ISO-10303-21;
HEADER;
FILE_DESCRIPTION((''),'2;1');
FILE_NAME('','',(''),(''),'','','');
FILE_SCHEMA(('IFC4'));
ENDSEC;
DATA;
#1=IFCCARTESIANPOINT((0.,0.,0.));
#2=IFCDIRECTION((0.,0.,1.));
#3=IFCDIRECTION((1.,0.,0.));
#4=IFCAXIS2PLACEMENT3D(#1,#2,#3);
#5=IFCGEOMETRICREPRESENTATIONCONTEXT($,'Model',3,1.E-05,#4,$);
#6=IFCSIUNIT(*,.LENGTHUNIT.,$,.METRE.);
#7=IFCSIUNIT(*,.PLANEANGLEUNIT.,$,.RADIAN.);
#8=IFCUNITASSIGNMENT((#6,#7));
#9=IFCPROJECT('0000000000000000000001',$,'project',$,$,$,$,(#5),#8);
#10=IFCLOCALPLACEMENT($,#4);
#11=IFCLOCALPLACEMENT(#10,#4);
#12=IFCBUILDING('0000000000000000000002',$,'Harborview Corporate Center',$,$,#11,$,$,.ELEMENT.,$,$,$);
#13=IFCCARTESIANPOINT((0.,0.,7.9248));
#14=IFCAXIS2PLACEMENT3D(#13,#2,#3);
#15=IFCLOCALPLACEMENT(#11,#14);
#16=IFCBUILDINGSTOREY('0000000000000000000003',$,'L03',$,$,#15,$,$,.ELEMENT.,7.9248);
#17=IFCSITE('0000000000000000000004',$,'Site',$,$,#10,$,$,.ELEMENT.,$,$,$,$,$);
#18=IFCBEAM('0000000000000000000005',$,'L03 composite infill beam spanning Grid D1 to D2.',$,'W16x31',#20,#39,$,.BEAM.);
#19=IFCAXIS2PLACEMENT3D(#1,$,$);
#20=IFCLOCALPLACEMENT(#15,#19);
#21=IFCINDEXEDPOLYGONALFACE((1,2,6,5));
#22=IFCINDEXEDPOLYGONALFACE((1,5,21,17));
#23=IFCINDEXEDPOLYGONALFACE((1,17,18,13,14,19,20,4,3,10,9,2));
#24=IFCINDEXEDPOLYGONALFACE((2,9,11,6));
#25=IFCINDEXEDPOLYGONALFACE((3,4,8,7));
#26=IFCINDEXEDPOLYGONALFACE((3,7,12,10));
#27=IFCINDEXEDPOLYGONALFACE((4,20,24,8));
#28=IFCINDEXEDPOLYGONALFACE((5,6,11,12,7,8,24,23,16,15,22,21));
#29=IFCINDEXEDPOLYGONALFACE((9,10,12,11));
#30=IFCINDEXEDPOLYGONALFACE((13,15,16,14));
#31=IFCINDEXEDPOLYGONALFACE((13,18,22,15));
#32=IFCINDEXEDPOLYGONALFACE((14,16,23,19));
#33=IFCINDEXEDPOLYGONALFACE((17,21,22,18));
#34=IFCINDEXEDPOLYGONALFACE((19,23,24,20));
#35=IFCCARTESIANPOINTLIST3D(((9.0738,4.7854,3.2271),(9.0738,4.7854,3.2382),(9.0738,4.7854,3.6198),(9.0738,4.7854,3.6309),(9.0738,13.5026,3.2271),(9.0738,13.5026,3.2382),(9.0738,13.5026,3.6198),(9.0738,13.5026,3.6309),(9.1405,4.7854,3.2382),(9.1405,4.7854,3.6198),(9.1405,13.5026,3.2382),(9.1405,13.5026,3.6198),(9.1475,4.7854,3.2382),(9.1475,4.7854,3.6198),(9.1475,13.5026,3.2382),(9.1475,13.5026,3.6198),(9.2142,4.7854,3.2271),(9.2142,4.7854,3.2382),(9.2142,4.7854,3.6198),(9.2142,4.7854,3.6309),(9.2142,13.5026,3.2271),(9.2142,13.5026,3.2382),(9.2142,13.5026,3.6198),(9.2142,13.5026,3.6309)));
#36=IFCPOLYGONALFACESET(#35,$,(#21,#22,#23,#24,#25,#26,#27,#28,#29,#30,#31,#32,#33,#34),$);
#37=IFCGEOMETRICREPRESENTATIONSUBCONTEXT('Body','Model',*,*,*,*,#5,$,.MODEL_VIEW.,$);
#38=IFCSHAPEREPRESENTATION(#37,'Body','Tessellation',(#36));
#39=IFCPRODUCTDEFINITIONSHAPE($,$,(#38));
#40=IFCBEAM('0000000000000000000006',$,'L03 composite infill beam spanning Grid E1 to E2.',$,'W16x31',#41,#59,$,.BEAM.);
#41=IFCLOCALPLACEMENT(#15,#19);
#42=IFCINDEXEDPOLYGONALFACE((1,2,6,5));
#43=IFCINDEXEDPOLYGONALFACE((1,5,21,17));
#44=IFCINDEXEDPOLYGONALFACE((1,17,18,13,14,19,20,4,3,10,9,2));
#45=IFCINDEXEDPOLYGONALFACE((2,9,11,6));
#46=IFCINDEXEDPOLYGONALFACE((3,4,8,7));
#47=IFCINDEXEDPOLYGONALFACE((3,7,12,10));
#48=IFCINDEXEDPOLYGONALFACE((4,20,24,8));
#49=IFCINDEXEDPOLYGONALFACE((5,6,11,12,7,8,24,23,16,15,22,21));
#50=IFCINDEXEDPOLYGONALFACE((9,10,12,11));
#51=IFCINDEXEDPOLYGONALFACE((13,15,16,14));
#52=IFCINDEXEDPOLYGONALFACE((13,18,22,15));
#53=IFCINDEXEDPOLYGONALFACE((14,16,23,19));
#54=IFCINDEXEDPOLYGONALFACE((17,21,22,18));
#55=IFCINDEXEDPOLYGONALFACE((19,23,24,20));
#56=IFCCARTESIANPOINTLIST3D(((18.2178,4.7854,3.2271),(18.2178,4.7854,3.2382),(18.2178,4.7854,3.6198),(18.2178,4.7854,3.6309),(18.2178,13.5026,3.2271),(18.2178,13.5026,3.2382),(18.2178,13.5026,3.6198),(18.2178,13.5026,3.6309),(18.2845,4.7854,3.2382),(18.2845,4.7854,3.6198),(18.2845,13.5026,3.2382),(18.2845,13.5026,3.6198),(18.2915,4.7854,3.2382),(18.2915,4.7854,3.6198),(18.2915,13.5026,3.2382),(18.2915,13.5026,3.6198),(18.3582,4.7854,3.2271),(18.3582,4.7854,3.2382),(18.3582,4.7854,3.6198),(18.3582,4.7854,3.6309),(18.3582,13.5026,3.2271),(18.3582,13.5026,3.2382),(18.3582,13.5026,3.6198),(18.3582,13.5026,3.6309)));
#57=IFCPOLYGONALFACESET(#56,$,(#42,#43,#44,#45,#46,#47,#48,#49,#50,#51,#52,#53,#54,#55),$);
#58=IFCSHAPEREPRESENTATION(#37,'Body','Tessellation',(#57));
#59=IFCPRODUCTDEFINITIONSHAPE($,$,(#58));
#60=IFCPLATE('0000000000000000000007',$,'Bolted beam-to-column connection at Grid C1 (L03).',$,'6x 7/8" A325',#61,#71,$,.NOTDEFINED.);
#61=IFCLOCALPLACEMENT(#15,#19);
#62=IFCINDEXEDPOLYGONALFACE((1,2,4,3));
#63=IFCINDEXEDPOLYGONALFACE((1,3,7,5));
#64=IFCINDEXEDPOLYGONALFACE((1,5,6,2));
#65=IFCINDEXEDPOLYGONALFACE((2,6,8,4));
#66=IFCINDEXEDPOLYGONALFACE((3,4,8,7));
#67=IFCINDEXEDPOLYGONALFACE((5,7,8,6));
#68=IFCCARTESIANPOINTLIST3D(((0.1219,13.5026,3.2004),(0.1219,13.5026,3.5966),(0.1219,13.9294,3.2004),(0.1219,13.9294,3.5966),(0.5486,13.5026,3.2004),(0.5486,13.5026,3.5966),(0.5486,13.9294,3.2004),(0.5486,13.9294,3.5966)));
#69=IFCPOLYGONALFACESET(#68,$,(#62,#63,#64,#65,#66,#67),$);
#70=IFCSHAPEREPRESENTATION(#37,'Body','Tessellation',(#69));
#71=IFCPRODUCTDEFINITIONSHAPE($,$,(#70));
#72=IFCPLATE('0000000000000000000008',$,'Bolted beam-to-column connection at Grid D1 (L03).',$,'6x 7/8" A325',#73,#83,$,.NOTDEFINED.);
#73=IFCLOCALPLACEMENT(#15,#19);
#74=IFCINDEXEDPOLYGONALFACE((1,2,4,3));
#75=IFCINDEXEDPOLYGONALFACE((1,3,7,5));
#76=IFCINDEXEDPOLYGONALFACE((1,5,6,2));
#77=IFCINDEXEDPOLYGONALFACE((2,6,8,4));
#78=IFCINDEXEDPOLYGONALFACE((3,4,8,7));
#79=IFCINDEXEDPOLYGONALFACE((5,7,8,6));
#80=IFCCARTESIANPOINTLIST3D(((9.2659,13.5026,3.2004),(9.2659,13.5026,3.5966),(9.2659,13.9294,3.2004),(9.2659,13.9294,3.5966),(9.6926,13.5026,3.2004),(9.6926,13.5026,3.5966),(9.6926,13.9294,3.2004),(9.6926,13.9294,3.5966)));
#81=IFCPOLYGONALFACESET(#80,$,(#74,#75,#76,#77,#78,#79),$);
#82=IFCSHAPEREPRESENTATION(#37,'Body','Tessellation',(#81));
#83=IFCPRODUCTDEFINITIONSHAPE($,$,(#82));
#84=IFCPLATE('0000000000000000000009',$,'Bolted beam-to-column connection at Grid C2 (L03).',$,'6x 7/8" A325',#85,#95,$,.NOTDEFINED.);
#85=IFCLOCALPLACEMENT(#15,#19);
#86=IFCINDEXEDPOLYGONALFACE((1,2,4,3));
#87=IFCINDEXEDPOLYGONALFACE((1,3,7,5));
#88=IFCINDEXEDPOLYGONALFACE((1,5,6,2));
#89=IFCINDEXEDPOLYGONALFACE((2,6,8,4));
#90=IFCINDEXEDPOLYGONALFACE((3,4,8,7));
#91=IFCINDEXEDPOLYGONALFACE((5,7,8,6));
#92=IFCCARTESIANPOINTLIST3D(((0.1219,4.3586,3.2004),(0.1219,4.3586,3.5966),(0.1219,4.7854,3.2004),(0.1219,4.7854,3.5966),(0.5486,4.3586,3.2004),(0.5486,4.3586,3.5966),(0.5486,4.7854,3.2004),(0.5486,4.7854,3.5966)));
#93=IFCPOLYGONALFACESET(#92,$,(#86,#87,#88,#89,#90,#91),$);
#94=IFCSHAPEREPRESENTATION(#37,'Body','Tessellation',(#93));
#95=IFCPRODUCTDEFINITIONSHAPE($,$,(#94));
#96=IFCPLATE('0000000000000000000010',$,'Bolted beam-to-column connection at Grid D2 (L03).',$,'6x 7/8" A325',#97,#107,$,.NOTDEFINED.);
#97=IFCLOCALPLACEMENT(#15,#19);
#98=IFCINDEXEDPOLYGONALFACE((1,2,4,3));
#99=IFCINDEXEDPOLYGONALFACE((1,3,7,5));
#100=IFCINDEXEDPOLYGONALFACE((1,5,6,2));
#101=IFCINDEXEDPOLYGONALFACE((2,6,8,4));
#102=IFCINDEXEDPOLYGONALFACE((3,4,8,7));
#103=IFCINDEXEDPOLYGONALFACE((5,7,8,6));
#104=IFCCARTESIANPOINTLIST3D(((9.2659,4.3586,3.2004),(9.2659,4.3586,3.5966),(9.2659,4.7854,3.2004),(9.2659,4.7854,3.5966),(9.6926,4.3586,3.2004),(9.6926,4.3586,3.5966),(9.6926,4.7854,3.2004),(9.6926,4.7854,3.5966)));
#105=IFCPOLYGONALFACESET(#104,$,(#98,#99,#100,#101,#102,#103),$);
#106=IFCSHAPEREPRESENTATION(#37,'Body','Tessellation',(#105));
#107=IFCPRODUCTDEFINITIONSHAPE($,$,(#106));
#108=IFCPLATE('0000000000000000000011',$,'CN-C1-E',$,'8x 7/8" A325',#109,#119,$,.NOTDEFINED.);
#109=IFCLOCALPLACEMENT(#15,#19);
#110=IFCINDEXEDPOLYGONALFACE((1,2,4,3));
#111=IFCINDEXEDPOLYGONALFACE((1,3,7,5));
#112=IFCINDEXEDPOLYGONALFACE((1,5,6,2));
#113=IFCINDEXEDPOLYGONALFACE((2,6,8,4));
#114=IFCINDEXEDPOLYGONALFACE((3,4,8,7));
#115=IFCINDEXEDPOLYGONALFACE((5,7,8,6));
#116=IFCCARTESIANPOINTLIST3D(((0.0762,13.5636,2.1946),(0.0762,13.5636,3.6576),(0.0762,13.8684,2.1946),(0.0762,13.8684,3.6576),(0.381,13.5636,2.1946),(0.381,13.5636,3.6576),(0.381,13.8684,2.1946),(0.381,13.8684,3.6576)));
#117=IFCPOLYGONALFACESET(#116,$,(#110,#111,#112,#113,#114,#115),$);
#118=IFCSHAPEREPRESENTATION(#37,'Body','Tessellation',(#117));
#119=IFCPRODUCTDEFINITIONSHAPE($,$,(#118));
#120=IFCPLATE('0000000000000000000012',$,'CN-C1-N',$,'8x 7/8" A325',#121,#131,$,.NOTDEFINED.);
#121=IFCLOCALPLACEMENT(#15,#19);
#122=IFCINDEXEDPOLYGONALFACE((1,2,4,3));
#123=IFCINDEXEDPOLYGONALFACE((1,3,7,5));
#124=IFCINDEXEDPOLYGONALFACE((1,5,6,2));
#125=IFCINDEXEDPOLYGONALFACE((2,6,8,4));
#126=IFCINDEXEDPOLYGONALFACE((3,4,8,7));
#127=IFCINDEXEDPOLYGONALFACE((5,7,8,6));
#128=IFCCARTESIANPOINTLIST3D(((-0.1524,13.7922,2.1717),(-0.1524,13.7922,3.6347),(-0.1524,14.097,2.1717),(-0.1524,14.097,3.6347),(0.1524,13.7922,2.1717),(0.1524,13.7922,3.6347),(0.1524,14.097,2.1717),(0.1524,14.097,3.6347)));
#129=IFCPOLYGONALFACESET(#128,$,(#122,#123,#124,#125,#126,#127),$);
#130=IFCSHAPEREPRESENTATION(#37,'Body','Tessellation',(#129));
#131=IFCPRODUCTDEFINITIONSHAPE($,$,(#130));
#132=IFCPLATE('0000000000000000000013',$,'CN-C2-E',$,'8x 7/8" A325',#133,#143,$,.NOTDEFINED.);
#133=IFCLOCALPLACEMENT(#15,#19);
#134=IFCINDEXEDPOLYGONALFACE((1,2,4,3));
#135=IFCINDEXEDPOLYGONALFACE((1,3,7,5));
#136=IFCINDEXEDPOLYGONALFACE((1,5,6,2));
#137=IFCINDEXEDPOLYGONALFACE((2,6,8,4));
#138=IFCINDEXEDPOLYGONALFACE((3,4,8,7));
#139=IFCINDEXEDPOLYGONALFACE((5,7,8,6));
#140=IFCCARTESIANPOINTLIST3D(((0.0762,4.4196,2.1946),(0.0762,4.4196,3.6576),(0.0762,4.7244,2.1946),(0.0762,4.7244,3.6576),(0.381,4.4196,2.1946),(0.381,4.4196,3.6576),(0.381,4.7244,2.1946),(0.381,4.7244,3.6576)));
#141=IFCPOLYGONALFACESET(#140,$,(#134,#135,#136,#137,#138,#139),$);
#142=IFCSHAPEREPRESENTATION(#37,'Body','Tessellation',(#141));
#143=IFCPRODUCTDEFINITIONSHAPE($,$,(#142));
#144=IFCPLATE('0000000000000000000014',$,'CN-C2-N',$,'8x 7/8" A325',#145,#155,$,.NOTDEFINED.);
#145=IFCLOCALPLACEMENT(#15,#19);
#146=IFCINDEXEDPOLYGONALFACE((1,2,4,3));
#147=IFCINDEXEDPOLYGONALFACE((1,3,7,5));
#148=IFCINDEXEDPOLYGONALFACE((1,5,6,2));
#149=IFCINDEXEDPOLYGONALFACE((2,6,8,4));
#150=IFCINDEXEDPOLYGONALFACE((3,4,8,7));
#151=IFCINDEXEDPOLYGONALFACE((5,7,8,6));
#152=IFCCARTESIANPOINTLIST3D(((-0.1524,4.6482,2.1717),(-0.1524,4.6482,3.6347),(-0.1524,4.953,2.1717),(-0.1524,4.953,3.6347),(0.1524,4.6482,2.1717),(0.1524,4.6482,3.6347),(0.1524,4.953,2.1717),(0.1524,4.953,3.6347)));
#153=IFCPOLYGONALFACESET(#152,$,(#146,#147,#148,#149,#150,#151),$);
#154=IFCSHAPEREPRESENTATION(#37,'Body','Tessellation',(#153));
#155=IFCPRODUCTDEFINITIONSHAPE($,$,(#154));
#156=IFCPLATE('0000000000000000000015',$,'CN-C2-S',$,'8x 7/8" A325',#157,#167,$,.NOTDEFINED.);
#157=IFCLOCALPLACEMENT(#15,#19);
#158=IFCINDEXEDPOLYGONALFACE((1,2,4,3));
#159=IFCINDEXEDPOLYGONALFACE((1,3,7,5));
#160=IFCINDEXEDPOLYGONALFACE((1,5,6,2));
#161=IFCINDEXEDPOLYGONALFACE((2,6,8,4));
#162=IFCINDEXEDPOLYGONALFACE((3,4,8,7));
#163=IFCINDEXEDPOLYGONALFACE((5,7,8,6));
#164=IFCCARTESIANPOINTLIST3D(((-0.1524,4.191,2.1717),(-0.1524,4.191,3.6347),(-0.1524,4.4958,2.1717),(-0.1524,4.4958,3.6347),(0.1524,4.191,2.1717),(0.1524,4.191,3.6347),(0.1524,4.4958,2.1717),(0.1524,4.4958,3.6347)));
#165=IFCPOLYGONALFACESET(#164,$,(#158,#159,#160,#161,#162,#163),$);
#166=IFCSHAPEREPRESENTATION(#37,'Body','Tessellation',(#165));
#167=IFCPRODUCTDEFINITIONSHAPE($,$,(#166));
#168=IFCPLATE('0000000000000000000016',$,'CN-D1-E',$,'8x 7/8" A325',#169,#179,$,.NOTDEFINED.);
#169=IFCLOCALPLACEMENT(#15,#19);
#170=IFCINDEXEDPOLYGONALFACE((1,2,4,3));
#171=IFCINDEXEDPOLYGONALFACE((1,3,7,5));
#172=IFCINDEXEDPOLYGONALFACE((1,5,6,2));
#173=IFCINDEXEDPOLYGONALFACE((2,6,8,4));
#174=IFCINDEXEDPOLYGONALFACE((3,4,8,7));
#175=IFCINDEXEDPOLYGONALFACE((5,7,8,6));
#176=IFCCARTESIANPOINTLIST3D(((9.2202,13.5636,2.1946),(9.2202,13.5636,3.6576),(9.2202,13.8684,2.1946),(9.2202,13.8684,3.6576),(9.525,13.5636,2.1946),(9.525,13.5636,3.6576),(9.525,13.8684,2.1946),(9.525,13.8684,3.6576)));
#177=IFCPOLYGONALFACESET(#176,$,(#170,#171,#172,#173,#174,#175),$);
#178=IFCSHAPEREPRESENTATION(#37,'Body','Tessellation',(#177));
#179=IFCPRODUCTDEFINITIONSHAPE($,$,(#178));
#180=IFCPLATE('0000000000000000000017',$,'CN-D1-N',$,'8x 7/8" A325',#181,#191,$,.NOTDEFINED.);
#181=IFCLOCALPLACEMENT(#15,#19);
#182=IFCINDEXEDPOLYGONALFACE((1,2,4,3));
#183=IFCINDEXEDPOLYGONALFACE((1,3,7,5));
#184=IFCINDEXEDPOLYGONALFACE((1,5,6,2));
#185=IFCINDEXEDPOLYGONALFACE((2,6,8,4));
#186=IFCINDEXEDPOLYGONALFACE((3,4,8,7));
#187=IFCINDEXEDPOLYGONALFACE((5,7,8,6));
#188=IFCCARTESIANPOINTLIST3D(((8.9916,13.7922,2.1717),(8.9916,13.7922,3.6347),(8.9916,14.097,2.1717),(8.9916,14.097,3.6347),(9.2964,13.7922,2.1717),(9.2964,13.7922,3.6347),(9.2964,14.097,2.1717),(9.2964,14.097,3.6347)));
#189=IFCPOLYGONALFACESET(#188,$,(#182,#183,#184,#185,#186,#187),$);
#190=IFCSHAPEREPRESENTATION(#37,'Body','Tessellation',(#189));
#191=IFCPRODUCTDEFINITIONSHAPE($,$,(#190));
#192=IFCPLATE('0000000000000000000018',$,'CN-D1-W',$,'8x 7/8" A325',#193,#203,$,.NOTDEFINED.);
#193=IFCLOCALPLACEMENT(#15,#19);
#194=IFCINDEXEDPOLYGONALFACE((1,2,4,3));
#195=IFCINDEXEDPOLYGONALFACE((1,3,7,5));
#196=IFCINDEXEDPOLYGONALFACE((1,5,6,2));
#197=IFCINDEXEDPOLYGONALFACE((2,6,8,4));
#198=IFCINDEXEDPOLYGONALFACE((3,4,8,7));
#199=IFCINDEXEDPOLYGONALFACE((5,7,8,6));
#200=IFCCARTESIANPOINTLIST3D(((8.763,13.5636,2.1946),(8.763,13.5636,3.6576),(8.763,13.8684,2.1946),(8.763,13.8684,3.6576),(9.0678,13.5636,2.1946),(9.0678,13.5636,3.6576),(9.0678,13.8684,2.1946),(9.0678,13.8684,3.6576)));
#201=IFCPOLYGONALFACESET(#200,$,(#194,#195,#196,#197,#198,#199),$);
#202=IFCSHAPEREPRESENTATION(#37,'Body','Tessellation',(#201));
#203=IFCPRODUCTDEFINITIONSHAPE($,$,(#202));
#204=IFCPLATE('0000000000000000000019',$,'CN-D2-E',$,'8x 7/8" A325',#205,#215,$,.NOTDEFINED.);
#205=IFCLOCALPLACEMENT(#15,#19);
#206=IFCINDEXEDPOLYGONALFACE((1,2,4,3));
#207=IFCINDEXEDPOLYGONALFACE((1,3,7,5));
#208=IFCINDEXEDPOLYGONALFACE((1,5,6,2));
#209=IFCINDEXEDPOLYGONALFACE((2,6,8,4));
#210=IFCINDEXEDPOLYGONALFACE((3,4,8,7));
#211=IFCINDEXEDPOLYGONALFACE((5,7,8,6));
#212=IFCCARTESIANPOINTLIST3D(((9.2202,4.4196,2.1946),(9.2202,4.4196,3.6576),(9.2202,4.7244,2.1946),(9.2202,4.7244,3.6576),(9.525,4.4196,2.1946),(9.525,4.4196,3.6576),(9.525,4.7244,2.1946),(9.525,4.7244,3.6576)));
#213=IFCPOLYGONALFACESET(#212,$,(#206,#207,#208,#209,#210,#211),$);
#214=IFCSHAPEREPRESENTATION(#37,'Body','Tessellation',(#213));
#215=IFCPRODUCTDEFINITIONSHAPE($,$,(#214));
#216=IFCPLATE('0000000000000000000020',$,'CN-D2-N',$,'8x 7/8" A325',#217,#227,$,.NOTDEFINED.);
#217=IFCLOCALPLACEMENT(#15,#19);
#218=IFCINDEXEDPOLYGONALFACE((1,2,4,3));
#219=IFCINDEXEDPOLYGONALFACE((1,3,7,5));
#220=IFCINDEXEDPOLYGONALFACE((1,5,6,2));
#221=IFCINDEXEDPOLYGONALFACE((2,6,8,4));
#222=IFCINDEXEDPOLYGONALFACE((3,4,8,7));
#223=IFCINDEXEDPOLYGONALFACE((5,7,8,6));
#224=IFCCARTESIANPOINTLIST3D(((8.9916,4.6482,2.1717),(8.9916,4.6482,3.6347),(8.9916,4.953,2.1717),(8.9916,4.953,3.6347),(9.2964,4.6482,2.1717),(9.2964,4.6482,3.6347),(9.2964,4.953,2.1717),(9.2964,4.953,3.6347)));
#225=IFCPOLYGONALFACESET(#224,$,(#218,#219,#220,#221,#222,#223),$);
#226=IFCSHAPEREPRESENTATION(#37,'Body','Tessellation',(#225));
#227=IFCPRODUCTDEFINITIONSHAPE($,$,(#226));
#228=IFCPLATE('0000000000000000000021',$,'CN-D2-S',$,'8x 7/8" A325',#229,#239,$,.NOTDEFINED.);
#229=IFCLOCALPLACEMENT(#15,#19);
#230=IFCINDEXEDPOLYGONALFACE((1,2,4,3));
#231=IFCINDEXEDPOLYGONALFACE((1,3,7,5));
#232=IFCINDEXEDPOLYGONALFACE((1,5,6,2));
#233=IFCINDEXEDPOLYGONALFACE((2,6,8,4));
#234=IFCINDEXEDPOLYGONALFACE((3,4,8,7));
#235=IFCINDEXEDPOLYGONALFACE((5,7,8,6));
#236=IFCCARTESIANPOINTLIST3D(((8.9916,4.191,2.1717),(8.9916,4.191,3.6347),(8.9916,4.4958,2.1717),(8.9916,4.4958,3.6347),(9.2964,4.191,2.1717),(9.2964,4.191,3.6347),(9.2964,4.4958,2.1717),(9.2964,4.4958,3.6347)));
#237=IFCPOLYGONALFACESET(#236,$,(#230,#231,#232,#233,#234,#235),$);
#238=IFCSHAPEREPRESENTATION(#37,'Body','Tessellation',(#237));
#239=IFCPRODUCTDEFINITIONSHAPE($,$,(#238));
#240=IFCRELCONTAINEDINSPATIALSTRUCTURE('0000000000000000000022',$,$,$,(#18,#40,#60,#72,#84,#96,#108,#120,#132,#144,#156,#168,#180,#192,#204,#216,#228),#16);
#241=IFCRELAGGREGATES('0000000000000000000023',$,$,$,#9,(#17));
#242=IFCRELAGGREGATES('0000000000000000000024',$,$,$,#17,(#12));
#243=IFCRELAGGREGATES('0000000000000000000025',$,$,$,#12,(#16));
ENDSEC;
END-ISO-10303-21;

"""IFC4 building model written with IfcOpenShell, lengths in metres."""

from ifc_helpers import new_model, si_unit, frame, origin_with_axes, place, context, subcontext, project, spatial, rectangle, i_section, extrude, element, save


model = new_model("IFC4")

# Units and contexts
model_context = context("Model", 3, precision=1e-05, world=origin_with_axes())
body_context = subcontext(model_context, "Body", "Model", "MODEL_VIEW")
ifc_project = project(units=[si_unit("LENGTHUNIT", "METRE"), si_unit("PLANEANGLEUNIT", "RADIAN")], contexts=[model_context])

# Site, building, storey
site_placement = place(None, origin_with_axes())
site = spatial("IfcSite", under=ifc_project, at=site_placement, Name="Site", CompositionType="ELEMENT")
building_placement = place(site_placement, origin_with_axes())
building = spatial("IfcBuilding", under=site, at=building_placement, Name="Harborview Corporate Center", CompositionType="ELEMENT")
storey_placement = place(building_placement, frame((0.0, 0.0, 7.9248), z_axis=(0.0, 0.0, 1.0), x_axis=(1.0, 0.0, 0.0)))
storey = spatial("IfcBuildingStorey", under=building, at=storey_placement, Name="L03", CompositionType="ELEMENT", Elevation=7.9248)

# Beams
for number, where, z_axis, x_axis, name in (
    (1, (9.144, 4.7854, 3.429), (0.0, 1.0, 0.0), (-1.0, 0.0, 0.0), "L03 composite infill beam spanning Grid D1 to D2."),
    (2, (18.288, 4.7854, 3.429), (0.0, 1.0, 0.0), (-1.0, 0.0, 0.0), "L03 composite infill beam spanning Grid E1 to E2."),
):
    element("IfcBeam", number, at=place(storey_placement, frame(where, z_axis=z_axis, x_axis=x_axis)), inside=storey, Name=name, ObjectType="W16x31", PredefinedType="BEAM", context=body_context, shape_type="SweptSolid", body=[
        extrude(i_section(OverallWidth=0.1405, OverallDepth=0.4039, WebThickness=0.007, FlangeThickness=0.0112), origin_with_axes(), (0.0, 0.0, 1.0), 8.7173),
    ])

# Plates
plate_1_placement = place(storey_placement, frame((0.3353, 13.716, 3.2004), z_axis=(0.0, 0.0, 1.0), x_axis=(1.0, 0.0, 0.0)))
element("IfcPlate", 3, at=plate_1_placement, inside=storey, Name="Bolted beam-to-column connection at Grid C1 (L03).", ObjectType="6x 7/8\" A325", PredefinedType="NOTDEFINED", context=body_context, shape_type="SweptSolid", body=[
    extrude(rectangle(XDim=0.4267, YDim=0.4267), origin_with_axes(), (0.0, 0.0, 1.0), 0.3962),
])
plate_2_placement = place(storey_placement, frame((9.4793, 13.716, 3.2004), z_axis=(0.0, 0.0, 1.0), x_axis=(1.0, 0.0, 0.0)))
element("IfcPlate", 4, at=plate_2_placement, inside=storey, Name="Bolted beam-to-column connection at Grid D1 (L03).", ObjectType="6x 7/8\" A325", PredefinedType="NOTDEFINED", context=body_context, shape_type="SweptSolid", body=[
    extrude(rectangle(XDim=0.4267, YDim=0.4267), origin_with_axes(), (0.0, 0.0, 1.0), 0.3962),
])
plate_3_placement = place(storey_placement, frame((0.3353, 4.572, 3.2004), z_axis=(0.0, 0.0, 1.0), x_axis=(1.0, 0.0, 0.0)))
element("IfcPlate", 5, at=plate_3_placement, inside=storey, Name="Bolted beam-to-column connection at Grid C2 (L03).", ObjectType="6x 7/8\" A325", PredefinedType="NOTDEFINED", context=body_context, shape_type="SweptSolid", body=[
    extrude(rectangle(XDim=0.4267, YDim=0.4267), origin_with_axes(), (0.0, 0.0, 1.0), 0.3962),
])
plate_4_placement = place(storey_placement, frame((9.4793, 4.572, 3.2004), z_axis=(0.0, 0.0, 1.0), x_axis=(1.0, 0.0, 0.0)))
element("IfcPlate", 6, at=plate_4_placement, inside=storey, Name="Bolted beam-to-column connection at Grid D2 (L03).", ObjectType="6x 7/8\" A325", PredefinedType="NOTDEFINED", context=body_context, shape_type="SweptSolid", body=[
    extrude(rectangle(XDim=0.4267, YDim=0.4267), origin_with_axes(), (0.0, 0.0, 1.0), 0.3962),
])
for number, where, z_axis, x_axis, name in (
    (7, (0.2286, 13.716, 2.1946), (0.0, 0.0, 1.0), (1.0, 0.0, 0.0), "CN-C1-E"),
    (8, (0.0, 13.9446, 2.1717), (0.0, 0.0, 1.0), (1.0, 0.0, 0.0), "CN-C1-N"),
    (9, (0.2286, 4.572, 2.1946), (0.0, 0.0, 1.0), (1.0, 0.0, 0.0), "CN-C2-E"),
    (10, (0.0, 4.8006, 2.1717), (0.0, 0.0, 1.0), (1.0, 0.0, 0.0), "CN-C2-N"),
    (11, (0.0, 4.3434, 2.1717), (0.0, 0.0, 1.0), (1.0, 0.0, 0.0), "CN-C2-S"),
):
    element("IfcPlate", number, at=place(storey_placement, frame(where, z_axis=z_axis, x_axis=x_axis)), inside=storey, Name=name, ObjectType="8x 7/8\" A325", PredefinedType="NOTDEFINED", context=body_context, shape_type="SweptSolid", body=[
        extrude(rectangle(XDim=0.3048, YDim=0.3048), origin_with_axes(), (0.0, 0.0, 1.0), 1.463),
    ])
for number, where, z_axis, x_axis, name in (
    (12, (9.3726, 13.716, 2.1946), (0.0, 0.0, 1.0), (1.0, 0.0, 0.0), "CN-D1-E"),
    (13, (9.144, 13.9446, 2.1717), (0.0, 0.0, 1.0), (1.0, 0.0, 0.0), "CN-D1-N"),
    (14, (8.9154, 13.716, 2.1946), (0.0, 0.0, 1.0), (1.0, 0.0, 0.0), "CN-D1-W"),
    (15, (9.3726, 4.572, 2.1946), (0.0, 0.0, 1.0), (1.0, 0.0, 0.0), "CN-D2-E"),
    (16, (9.144, 4.8006, 2.1717), (0.0, 0.0, 1.0), (1.0, 0.0, 0.0), "CN-D2-N"),
    (17, (9.144, 4.3434, 2.1717), (0.0, 0.0, 1.0), (1.0, 0.0, 0.0), "CN-D2-S"),
):
    element("IfcPlate", number, at=place(storey_placement, frame(where, z_axis=z_axis, x_axis=x_axis)), inside=storey, Name=name, ObjectType="8x 7/8\" A325", PredefinedType="NOTDEFINED", context=body_context, shape_type="SweptSolid", body=[
        extrude(rectangle(XDim=0.3048, YDim=0.3048), origin_with_axes(), (0.0, 0.0, 1.0), 1.463),
    ])

save(model, "model.ifc")
